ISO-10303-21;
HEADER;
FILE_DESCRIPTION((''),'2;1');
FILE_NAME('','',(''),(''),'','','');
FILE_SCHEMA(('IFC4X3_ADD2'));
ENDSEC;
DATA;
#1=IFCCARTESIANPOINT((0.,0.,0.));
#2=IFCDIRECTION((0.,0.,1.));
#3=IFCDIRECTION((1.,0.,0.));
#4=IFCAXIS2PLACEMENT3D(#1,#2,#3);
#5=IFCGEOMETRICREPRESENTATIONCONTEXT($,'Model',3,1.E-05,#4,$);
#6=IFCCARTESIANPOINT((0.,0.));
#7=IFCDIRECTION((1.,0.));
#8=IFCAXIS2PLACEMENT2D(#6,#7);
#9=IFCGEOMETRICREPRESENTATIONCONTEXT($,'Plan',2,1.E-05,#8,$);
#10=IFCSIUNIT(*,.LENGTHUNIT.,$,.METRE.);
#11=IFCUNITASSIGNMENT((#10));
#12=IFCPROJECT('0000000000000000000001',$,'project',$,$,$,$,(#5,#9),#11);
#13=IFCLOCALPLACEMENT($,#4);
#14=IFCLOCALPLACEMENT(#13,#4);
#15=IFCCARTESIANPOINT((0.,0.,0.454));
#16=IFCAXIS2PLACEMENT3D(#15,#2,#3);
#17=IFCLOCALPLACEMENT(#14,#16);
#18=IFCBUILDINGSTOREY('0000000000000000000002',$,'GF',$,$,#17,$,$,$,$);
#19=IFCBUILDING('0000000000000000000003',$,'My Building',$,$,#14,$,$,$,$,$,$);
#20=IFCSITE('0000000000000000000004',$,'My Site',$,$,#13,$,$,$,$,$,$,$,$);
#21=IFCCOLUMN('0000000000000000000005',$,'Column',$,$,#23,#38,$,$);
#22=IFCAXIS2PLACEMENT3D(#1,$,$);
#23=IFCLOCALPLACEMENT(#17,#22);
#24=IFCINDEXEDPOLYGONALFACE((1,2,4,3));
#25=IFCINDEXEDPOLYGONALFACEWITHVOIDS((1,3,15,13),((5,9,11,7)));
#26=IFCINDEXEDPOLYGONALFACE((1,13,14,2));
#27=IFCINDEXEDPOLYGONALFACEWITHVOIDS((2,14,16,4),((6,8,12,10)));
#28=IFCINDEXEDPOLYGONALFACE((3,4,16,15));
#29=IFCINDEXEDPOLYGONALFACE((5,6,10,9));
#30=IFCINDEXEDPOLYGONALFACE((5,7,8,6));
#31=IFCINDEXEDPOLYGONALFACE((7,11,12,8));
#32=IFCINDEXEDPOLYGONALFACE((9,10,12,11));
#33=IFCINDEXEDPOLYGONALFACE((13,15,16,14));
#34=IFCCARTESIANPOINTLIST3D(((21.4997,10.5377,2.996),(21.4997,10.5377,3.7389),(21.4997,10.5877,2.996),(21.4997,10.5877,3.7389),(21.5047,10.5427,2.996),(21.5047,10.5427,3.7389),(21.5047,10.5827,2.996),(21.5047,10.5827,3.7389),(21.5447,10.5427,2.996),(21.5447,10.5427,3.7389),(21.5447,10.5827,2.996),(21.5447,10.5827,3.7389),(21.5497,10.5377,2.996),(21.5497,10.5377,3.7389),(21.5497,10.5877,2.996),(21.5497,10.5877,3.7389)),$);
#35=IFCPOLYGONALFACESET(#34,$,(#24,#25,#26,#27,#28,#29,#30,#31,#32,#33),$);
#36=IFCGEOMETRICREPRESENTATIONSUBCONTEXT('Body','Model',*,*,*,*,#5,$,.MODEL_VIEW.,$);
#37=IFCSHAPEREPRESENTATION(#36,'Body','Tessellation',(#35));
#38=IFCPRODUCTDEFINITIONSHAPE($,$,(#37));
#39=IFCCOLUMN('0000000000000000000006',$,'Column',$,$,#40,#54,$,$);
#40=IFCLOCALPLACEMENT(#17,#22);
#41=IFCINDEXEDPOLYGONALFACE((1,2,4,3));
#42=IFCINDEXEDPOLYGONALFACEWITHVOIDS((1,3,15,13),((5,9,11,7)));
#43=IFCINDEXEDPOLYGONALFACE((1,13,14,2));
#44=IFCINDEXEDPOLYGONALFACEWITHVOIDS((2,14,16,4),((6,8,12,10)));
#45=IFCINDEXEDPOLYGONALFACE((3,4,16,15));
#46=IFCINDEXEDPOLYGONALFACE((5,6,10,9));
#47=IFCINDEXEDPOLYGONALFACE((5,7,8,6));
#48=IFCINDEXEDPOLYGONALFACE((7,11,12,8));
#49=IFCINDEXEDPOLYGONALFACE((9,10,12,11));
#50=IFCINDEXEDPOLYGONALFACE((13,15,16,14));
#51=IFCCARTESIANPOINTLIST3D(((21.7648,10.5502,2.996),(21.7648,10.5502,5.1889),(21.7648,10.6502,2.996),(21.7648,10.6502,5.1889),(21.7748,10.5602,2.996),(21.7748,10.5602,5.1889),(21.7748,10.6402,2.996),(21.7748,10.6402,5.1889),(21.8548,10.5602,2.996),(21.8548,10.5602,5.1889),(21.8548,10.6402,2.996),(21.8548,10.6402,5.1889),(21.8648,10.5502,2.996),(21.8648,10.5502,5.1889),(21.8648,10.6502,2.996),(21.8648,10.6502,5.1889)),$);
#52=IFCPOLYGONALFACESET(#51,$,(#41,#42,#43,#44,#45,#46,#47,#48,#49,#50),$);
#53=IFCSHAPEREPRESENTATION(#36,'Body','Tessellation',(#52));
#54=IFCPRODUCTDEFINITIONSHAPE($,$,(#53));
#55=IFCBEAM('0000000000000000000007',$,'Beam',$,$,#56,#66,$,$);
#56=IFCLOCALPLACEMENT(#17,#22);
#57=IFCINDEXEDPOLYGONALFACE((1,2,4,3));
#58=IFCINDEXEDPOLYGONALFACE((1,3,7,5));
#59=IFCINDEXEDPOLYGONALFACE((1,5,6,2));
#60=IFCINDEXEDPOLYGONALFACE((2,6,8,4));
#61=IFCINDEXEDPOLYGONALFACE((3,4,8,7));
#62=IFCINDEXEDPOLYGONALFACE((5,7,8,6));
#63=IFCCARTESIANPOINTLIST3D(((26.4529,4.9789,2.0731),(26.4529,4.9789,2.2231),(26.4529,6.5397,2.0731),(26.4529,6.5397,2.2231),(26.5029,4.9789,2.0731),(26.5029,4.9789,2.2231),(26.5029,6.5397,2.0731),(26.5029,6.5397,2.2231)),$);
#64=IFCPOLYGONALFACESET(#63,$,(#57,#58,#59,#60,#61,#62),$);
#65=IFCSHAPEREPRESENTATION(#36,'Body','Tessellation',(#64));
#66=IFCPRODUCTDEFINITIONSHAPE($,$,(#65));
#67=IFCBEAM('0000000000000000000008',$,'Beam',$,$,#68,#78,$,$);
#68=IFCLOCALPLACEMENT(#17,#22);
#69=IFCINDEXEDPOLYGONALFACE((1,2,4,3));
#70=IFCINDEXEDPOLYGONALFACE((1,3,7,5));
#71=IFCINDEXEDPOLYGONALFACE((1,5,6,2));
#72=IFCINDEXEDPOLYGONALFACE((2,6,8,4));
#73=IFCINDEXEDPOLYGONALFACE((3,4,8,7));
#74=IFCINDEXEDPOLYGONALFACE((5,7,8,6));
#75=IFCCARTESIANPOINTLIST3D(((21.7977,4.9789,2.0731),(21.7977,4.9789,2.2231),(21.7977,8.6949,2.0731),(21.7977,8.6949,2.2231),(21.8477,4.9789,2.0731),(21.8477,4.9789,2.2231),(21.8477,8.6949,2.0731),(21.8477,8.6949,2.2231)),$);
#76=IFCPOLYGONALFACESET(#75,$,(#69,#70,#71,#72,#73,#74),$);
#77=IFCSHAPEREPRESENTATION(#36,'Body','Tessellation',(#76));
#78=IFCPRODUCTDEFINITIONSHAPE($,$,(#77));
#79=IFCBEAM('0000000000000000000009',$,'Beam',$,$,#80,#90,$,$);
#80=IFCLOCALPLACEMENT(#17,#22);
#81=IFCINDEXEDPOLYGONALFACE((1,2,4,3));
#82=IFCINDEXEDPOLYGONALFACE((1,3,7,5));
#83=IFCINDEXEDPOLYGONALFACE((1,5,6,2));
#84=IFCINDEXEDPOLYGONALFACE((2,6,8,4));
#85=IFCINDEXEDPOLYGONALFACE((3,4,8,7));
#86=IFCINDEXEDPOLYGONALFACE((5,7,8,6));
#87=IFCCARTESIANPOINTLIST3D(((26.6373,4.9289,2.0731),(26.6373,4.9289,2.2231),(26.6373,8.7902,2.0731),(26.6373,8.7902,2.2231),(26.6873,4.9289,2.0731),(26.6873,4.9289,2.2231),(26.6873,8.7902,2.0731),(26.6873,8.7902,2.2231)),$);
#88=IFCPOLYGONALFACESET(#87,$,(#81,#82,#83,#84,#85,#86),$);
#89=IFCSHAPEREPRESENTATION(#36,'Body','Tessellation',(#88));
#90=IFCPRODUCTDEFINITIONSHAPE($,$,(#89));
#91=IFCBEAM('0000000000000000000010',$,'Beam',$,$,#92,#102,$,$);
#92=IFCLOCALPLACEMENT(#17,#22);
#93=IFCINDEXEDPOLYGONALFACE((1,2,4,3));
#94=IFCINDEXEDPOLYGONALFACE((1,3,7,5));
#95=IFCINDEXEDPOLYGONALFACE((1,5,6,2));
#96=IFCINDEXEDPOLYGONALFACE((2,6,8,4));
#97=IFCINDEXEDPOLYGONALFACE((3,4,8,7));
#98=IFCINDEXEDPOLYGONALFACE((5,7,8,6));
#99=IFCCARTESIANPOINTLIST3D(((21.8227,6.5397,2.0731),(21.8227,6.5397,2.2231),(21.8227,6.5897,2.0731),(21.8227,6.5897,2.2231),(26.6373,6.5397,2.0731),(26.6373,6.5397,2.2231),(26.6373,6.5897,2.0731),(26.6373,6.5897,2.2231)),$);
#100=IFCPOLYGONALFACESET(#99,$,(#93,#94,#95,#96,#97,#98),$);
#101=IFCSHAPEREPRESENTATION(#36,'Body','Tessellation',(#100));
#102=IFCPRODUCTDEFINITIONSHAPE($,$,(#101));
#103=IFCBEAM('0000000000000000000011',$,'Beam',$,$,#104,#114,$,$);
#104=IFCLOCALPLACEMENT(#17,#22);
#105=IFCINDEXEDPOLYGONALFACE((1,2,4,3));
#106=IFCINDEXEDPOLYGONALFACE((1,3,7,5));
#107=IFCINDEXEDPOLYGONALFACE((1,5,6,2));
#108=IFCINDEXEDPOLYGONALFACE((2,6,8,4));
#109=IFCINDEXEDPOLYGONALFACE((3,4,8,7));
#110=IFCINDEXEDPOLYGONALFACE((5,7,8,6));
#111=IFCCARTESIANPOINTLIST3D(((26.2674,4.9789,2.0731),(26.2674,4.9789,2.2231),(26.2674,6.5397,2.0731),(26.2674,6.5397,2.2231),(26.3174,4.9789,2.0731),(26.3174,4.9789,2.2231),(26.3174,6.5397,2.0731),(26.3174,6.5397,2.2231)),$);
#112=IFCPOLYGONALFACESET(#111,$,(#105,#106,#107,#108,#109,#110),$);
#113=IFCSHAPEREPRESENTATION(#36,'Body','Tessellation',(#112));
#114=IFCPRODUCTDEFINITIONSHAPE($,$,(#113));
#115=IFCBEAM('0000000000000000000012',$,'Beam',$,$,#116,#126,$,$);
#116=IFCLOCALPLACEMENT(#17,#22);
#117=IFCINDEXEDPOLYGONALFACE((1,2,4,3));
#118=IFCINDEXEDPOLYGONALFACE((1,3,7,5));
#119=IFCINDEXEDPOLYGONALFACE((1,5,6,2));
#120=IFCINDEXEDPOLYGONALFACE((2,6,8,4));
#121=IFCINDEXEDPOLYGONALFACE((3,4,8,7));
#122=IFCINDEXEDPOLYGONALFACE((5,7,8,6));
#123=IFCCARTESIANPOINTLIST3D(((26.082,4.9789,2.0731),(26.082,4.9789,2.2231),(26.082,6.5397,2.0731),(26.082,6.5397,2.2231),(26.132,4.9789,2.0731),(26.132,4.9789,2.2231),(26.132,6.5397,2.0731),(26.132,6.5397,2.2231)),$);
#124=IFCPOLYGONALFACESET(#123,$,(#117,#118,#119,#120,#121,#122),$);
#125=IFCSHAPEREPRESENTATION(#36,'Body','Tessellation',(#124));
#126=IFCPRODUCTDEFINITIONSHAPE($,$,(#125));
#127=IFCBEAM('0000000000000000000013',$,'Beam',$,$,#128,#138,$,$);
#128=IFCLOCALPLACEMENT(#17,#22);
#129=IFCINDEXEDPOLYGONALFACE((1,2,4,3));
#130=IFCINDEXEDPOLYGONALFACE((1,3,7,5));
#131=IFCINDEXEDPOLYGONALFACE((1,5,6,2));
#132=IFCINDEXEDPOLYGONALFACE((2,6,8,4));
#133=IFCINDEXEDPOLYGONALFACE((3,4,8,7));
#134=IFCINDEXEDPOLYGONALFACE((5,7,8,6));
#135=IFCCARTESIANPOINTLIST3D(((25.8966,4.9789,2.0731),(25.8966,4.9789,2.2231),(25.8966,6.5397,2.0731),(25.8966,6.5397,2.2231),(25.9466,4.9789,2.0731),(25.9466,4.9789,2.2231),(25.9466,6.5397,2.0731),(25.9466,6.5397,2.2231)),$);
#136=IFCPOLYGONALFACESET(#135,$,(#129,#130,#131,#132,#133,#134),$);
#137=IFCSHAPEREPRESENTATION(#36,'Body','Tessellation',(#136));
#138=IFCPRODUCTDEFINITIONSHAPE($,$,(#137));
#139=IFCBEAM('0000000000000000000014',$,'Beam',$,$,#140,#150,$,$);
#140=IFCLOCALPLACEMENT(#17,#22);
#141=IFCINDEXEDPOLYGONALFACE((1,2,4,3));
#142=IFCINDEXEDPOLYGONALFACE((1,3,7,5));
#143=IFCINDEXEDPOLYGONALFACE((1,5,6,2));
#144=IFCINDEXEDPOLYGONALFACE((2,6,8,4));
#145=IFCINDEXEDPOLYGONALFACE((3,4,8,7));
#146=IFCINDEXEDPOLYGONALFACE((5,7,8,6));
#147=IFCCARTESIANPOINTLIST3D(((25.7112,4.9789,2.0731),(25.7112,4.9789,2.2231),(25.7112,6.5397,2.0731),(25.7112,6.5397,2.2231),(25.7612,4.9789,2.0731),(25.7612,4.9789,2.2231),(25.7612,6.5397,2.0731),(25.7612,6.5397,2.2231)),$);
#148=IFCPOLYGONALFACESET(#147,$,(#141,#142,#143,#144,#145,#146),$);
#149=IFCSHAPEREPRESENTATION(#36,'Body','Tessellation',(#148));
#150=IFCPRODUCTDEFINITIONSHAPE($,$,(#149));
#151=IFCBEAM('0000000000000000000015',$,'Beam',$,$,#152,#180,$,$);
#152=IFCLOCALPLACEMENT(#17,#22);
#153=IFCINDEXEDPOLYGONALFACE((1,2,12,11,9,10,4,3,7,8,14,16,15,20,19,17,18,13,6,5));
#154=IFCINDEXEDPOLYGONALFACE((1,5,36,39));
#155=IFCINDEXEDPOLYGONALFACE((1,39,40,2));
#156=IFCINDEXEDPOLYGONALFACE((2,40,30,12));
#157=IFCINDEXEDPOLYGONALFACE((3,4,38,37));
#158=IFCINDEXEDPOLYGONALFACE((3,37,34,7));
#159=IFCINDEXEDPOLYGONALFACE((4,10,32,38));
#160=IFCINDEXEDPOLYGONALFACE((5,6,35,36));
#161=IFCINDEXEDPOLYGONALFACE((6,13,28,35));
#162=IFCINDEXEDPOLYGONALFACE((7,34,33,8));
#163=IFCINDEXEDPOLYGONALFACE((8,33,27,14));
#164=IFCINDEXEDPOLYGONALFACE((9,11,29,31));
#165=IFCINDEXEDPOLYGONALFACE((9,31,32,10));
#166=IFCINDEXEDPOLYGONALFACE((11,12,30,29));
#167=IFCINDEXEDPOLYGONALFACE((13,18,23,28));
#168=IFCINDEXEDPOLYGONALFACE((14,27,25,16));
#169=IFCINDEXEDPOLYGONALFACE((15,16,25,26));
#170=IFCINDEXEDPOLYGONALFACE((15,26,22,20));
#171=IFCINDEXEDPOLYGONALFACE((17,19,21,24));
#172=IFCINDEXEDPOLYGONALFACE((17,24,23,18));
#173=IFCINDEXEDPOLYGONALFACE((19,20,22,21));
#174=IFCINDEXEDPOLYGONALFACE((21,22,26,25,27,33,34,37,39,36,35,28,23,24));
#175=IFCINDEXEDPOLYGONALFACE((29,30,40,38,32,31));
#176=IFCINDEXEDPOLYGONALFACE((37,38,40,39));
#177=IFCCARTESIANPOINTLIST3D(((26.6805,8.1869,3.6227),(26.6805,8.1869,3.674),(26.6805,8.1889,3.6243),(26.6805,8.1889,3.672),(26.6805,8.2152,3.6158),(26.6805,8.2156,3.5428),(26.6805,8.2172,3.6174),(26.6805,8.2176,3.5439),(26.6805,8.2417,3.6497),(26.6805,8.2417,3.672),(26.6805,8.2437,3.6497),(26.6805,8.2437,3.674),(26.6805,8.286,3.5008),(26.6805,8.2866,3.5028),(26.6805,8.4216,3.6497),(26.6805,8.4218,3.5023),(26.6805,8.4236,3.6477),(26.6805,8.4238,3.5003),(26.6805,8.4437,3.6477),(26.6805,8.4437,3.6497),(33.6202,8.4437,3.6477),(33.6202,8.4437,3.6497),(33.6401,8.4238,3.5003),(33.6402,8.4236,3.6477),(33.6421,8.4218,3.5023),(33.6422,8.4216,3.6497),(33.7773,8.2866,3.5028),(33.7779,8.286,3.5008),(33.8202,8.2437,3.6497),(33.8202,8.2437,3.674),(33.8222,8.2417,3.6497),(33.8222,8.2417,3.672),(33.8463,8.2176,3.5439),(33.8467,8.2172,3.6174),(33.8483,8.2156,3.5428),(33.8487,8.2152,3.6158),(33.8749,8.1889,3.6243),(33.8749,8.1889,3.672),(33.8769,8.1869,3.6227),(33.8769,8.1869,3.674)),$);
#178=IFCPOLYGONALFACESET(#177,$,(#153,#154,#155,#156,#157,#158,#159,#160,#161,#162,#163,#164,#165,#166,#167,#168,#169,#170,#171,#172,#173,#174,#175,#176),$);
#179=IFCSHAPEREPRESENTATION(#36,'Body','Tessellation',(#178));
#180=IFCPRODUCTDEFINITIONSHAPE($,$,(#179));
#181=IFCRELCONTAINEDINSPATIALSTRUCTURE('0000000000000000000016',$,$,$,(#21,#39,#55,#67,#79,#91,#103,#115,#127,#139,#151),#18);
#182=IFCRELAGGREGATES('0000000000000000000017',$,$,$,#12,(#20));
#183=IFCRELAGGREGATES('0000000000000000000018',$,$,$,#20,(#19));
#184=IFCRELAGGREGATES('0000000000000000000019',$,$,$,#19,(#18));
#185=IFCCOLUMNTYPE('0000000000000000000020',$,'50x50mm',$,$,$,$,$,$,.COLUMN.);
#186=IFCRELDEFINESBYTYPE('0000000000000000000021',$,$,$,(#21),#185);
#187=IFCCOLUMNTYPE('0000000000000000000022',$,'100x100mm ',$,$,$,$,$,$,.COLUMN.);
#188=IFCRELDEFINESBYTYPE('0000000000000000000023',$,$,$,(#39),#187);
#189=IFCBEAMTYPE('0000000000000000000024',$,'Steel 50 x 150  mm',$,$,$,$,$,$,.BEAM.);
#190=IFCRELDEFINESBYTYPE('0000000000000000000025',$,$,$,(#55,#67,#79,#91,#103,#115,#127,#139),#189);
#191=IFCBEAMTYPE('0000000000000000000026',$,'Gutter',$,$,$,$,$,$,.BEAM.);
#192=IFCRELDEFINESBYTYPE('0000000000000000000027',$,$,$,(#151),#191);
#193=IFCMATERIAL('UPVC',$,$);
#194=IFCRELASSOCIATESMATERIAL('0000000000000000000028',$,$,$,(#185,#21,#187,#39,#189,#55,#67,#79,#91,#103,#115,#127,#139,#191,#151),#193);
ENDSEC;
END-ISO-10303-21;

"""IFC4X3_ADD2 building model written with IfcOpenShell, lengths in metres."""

from ifc_helpers import new_model, entity, si_unit, frame, origin_with_axes, origin_2d_with_axis, place, context, subcontext, project, spatial, indexed_curve, rectangle, hollow_rectangle, outline, extrude, clip, halfspace, shape, material, material_profile, profile_set, profile_usage, type_object, element, save


model = new_model("IFC4X3_ADD2")

# Units and contexts
model_context = context("Model", 3, precision=1e-05, world=origin_with_axes())
plan_context = context("Plan", 2, precision=1e-05, world=origin_2d_with_axis())
body_context_1 = subcontext(model_context, "Body", "Model", "MODEL_VIEW")
body_context_2 = subcontext(plan_context, "Body", "Plan", "PLAN_VIEW")
ifc_project = project(units=[si_unit("LENGTHUNIT", "METRE")], contexts=[model_context, plan_context])

# Site, building, storey
site_placement = place(None, origin_with_axes())
site = spatial("IfcSite", under=ifc_project, at=site_placement, Name="My Site")
building_placement = place(site_placement, origin_with_axes())
building = spatial("IfcBuilding", under=site, at=building_placement, Name="My Building")
storey_placement = place(building_placement, frame((0.0, 0.0, 0.454), z_axis=(0.0, 0.0, 1.0), x_axis=(1.0, 0.0, 0.0)))
storey = spatial("IfcBuildingStorey", under=building, at=storey_placement, Name="GF")

# Columns
ifc_material_1 = material(Name="UPVC")
ifc_material_profile_1 = material_profile(ifc_material_1, hollow_rectangle(XDim=0.05, YDim=0.05, WallThickness=0.005))
ifc_profile_set_1 = profile_set([ifc_material_profile_1])
ifc_profile_usage_1 = profile_usage(ifc_profile_set_1)
column_type_1 = type_object("IfcColumnType", Name="50x50mm", PredefinedType="COLUMN", material=ifc_profile_set_1)
column_1_placement = place(storey_placement, frame((21.5247, 10.5627, 2.996), z_axis=(0.0, 0.0, 1.0), x_axis=(1.0, 0.0, 0.0)))
element("IfcColumn", 1, at=column_1_placement, inside=storey, type_object=column_type_1, material=ifc_profile_usage_1, Name="Column", context=body_context_1, shape_type="SweptSolid", body=[
    extrude(hollow_rectangle(XDim=0.05, YDim=0.05, WallThickness=0.005), origin_with_axes(), (0.0, 0.0, 1.0), 0.7429),
])
ifc_material_profile_2 = material_profile(ifc_material_1, hollow_rectangle(XDim=0.1, YDim=0.1, WallThickness=0.01))
ifc_profile_set_2 = profile_set([ifc_material_profile_2])
ifc_profile_usage_2 = profile_usage(ifc_profile_set_2)
column_type_2 = type_object("IfcColumnType", Name="100x100mm ", PredefinedType="COLUMN", material=ifc_profile_set_2)
column_2_placement = place(storey_placement, frame((21.8148, 10.6002, 2.996), z_axis=(0.0, 0.0, 1.0), x_axis=(0.0, -1.0, 0.0)))
element("IfcColumn", 2, at=column_2_placement, inside=storey, type_object=column_type_2, material=ifc_profile_usage_2, Name="Column", shapes=[
    shape(body_context_1, "Body", "SweptSolid", [extrude(hollow_rectangle(XDim=0.1, YDim=0.1, WallThickness=0.01), origin_with_axes(), (0.0, 0.0, 1.0), 2.1929)]),
    shape(body_context_2, "Body", "Annotation2D", [entity("IfcGeometricCurveSet", [entity("IfcIndexedPolyCurve", entity("IfcCartesianPointList2D", [[0.04, -0.04], [0.04, 0.04], [-0.04, 0.04], [-0.04, -0.04]]), [entity("IfcLineIndex", [1, 2, 3, 4, 1])]), entity("IfcIndexedPolyCurve", entity("IfcCartesianPointList2D", [[-0.05, -0.05], [-0.05, 0.05], [0.05, 0.05], [0.05, -0.05]]), [entity("IfcLineIndex", [1, 2, 3, 4, 1])])])]),
])

# Beams
ifc_material_profile_3 = material_profile(ifc_material_1, rectangle(XDim=0.05, YDim=0.15))
ifc_profile_set_3 = profile_set([ifc_material_profile_3])
ifc_profile_usage_3 = profile_usage(ifc_profile_set_3)
beam_type_1 = type_object("IfcBeamType", Name="Steel 50 x 150  mm", PredefinedType="BEAM", material=ifc_profile_set_3)
beam_1_placement = place(storey_placement, frame((26.4779, 6.5397, 2.1481), z_axis=(0.0, -1.0, 0.0), x_axis=(1.0, 0.0, 0.0)))
element("IfcBeam", 3, at=beam_1_placement, inside=storey, type_object=beam_type_1, material=ifc_profile_usage_3, Name="Beam", context=body_context_1, shape_type="SweptSolid", body=[
    extrude(rectangle(XDim=0.05, YDim=0.15), origin_with_axes(), (0.0, 0.0, 1.0), 1.5608),
])
ifc_profile_usage_4 = profile_usage(ifc_profile_set_3)
beam_2_placement = place(storey_placement, frame((21.8227, 8.6949, 2.1481), z_axis=(0.0, -1.0, 0.0), x_axis=(1.0, 0.0, 0.0)))
element("IfcBeam", 4, at=beam_2_placement, inside=storey, type_object=beam_type_1, material=ifc_profile_usage_4, Name="Beam", context=body_context_1, shape_type="SweptSolid", body=[
    extrude(rectangle(XDim=0.05, YDim=0.15), origin_with_axes(), (0.0, 0.0, 1.0), 3.716),
])
ifc_profile_usage_5 = profile_usage(ifc_profile_set_3)
beam_3_placement = place(storey_placement, frame((26.6623, 8.7902, 2.1481), z_axis=(0.0, -1.0, 0.0), x_axis=(1.0, 0.0, 0.0)))
element("IfcBeam", 5, at=beam_3_placement, inside=storey, type_object=beam_type_1, material=ifc_profile_usage_5, Name="Beam", context=body_context_1, shape_type="SweptSolid", body=[
    extrude(rectangle(XDim=0.05, YDim=0.15), origin_with_axes(), (0.0, 0.0, 1.0), 3.8613),
])
ifc_profile_usage_6 = profile_usage(ifc_profile_set_3)
beam_4_placement = place(storey_placement, frame((21.8227, 6.5647, 2.1481), z_axis=(1.0, 0.0, 0.0), x_axis=(0.0, 1.0, 0.0)))
element("IfcBeam", 6, at=beam_4_placement, inside=storey, type_object=beam_type_1, material=ifc_profile_usage_6, Name="Beam", context=body_context_1, shape_type="SweptSolid", body=[
    extrude(rectangle(XDim=0.05, YDim=0.15), origin_with_axes(), (0.0, 0.0, 1.0), 4.8146),
])
ifc_profile_usage_7 = profile_usage(ifc_profile_set_3)
beam_5_placement = place(storey_placement, frame((26.2924, 6.5397, 2.1481), z_axis=(0.0, -1.0, 0.0), x_axis=(1.0, 0.0, 0.0)))
element("IfcBeam", 7, at=beam_5_placement, inside=storey, type_object=beam_type_1, material=ifc_profile_usage_7, Name="Beam", context=body_context_1, shape_type="SweptSolid", body=[
    extrude(rectangle(XDim=0.05, YDim=0.15), origin_with_axes(), (0.0, 0.0, 1.0), 1.5608),
])
ifc_profile_usage_8 = profile_usage(ifc_profile_set_3)
beam_6_placement = place(storey_placement, frame((26.107, 6.5397, 2.1481), z_axis=(0.0, -1.0, 0.0), x_axis=(1.0, 0.0, 0.0)))
element("IfcBeam", 8, at=beam_6_placement, inside=storey, type_object=beam_type_1, material=ifc_profile_usage_8, Name="Beam", context=body_context_1, shape_type="SweptSolid", body=[
    extrude(rectangle(XDim=0.05, YDim=0.15), origin_with_axes(), (0.0, 0.0, 1.0), 1.5608),
])
ifc_profile_usage_9 = profile_usage(ifc_profile_set_3)
beam_7_placement = place(storey_placement, frame((25.9216, 6.5397, 2.1481), z_axis=(0.0, -1.0, 0.0), x_axis=(1.0, 0.0, 0.0)))
element("IfcBeam", 9, at=beam_7_placement, inside=storey, type_object=beam_type_1, material=ifc_profile_usage_9, Name="Beam", context=body_context_1, shape_type="SweptSolid", body=[
    extrude(rectangle(XDim=0.05, YDim=0.15), origin_with_axes(), (0.0, 0.0, 1.0), 1.5608),
])
ifc_profile_usage_10 = profile_usage(ifc_profile_set_3)
beam_8_placement = place(storey_placement, frame((25.7362, 6.5397, 2.1481), z_axis=(0.0, -1.0, 0.0), x_axis=(1.0, 0.0, 0.0)))
element("IfcBeam", 10, at=beam_8_placement, inside=storey, type_object=beam_type_1, material=ifc_profile_usage_10, Name="Beam", context=body_context_1, shape_type="SweptSolid", body=[
    extrude(rectangle(XDim=0.05, YDim=0.15), origin_with_axes(), (0.0, 0.0, 1.0), 1.5608),
])
ifc_material_profile_4 = material_profile(ifc_material_1, outline(indexed_curve([(0.0548, 0.1717), (0.002, 0.1717), (0.002, 0.124), (0.0303, 0.1171), (0.0307, 0.0436), (0.0996, 0.0025), (0.2349, 0.002), (0.2347, 0.1494), (0.2567, 0.1494), (0.2567, 0.1474), (0.2367, 0.1474), (0.2369, 0.0), (0.0991, 0.0005), (0.0287, 0.0425), (0.0283, 0.1155), (0.0, 0.1224), (0.0, 0.1737), (0.0568, 0.1737), (0.0568, 0.1494), (0.0548, 0.1494), (0.0548, 0.1717)])))
ifc_profile_set_4 = profile_set([ifc_material_profile_4])
ifc_profile_usage_11 = profile_usage(ifc_profile_set_4)
beam_type_2 = type_object("IfcBeamType", Name="Gutter", PredefinedType="BEAM", material=ifc_profile_set_4)
beam_9_placement = place(storey_placement, frame((26.6805, 8.1869, 3.5003), z_axis=(1.0, 0.0, 0.0), x_axis=(0.0, 1.0, 0.0)))
element("IfcBeam", 11, at=beam_9_placement, inside=storey, type_object=beam_type_2, material=ifc_profile_usage_11, Name="Beam", context=body_context_1, shape_type="Clipping", body=[
    clip(extrude(outline(indexed_curve([(0.0548, 0.1717), (0.002, 0.1717), (0.002, 0.124), (0.0303, 0.1171), (0.0307, 0.0436), (0.0996, 0.0025), (0.2349, 0.002), (0.2347, 0.1494), (0.2567, 0.1494), (0.2567, 0.1474), (0.2367, 0.1474), (0.2369, 0.0), (0.0991, 0.0005), (0.0287, 0.0425), (0.0283, 0.1155), (0.0, 0.1224), (0.0, 0.1737), (0.0568, 0.1737), (0.0568, 0.1494), (0.0548, 0.1494), (0.0548, 0.1717)])), origin_with_axes(), (0.0, 0.0, 1.0), 7.1965), halfspace(frame((0.0, -3.9543, 7.1965), z_axis=(0.70711, 0.0, 0.707104), x_axis=(0.0, -1.0, 0.0)), False)),
])

save(model, "model.ifc")
